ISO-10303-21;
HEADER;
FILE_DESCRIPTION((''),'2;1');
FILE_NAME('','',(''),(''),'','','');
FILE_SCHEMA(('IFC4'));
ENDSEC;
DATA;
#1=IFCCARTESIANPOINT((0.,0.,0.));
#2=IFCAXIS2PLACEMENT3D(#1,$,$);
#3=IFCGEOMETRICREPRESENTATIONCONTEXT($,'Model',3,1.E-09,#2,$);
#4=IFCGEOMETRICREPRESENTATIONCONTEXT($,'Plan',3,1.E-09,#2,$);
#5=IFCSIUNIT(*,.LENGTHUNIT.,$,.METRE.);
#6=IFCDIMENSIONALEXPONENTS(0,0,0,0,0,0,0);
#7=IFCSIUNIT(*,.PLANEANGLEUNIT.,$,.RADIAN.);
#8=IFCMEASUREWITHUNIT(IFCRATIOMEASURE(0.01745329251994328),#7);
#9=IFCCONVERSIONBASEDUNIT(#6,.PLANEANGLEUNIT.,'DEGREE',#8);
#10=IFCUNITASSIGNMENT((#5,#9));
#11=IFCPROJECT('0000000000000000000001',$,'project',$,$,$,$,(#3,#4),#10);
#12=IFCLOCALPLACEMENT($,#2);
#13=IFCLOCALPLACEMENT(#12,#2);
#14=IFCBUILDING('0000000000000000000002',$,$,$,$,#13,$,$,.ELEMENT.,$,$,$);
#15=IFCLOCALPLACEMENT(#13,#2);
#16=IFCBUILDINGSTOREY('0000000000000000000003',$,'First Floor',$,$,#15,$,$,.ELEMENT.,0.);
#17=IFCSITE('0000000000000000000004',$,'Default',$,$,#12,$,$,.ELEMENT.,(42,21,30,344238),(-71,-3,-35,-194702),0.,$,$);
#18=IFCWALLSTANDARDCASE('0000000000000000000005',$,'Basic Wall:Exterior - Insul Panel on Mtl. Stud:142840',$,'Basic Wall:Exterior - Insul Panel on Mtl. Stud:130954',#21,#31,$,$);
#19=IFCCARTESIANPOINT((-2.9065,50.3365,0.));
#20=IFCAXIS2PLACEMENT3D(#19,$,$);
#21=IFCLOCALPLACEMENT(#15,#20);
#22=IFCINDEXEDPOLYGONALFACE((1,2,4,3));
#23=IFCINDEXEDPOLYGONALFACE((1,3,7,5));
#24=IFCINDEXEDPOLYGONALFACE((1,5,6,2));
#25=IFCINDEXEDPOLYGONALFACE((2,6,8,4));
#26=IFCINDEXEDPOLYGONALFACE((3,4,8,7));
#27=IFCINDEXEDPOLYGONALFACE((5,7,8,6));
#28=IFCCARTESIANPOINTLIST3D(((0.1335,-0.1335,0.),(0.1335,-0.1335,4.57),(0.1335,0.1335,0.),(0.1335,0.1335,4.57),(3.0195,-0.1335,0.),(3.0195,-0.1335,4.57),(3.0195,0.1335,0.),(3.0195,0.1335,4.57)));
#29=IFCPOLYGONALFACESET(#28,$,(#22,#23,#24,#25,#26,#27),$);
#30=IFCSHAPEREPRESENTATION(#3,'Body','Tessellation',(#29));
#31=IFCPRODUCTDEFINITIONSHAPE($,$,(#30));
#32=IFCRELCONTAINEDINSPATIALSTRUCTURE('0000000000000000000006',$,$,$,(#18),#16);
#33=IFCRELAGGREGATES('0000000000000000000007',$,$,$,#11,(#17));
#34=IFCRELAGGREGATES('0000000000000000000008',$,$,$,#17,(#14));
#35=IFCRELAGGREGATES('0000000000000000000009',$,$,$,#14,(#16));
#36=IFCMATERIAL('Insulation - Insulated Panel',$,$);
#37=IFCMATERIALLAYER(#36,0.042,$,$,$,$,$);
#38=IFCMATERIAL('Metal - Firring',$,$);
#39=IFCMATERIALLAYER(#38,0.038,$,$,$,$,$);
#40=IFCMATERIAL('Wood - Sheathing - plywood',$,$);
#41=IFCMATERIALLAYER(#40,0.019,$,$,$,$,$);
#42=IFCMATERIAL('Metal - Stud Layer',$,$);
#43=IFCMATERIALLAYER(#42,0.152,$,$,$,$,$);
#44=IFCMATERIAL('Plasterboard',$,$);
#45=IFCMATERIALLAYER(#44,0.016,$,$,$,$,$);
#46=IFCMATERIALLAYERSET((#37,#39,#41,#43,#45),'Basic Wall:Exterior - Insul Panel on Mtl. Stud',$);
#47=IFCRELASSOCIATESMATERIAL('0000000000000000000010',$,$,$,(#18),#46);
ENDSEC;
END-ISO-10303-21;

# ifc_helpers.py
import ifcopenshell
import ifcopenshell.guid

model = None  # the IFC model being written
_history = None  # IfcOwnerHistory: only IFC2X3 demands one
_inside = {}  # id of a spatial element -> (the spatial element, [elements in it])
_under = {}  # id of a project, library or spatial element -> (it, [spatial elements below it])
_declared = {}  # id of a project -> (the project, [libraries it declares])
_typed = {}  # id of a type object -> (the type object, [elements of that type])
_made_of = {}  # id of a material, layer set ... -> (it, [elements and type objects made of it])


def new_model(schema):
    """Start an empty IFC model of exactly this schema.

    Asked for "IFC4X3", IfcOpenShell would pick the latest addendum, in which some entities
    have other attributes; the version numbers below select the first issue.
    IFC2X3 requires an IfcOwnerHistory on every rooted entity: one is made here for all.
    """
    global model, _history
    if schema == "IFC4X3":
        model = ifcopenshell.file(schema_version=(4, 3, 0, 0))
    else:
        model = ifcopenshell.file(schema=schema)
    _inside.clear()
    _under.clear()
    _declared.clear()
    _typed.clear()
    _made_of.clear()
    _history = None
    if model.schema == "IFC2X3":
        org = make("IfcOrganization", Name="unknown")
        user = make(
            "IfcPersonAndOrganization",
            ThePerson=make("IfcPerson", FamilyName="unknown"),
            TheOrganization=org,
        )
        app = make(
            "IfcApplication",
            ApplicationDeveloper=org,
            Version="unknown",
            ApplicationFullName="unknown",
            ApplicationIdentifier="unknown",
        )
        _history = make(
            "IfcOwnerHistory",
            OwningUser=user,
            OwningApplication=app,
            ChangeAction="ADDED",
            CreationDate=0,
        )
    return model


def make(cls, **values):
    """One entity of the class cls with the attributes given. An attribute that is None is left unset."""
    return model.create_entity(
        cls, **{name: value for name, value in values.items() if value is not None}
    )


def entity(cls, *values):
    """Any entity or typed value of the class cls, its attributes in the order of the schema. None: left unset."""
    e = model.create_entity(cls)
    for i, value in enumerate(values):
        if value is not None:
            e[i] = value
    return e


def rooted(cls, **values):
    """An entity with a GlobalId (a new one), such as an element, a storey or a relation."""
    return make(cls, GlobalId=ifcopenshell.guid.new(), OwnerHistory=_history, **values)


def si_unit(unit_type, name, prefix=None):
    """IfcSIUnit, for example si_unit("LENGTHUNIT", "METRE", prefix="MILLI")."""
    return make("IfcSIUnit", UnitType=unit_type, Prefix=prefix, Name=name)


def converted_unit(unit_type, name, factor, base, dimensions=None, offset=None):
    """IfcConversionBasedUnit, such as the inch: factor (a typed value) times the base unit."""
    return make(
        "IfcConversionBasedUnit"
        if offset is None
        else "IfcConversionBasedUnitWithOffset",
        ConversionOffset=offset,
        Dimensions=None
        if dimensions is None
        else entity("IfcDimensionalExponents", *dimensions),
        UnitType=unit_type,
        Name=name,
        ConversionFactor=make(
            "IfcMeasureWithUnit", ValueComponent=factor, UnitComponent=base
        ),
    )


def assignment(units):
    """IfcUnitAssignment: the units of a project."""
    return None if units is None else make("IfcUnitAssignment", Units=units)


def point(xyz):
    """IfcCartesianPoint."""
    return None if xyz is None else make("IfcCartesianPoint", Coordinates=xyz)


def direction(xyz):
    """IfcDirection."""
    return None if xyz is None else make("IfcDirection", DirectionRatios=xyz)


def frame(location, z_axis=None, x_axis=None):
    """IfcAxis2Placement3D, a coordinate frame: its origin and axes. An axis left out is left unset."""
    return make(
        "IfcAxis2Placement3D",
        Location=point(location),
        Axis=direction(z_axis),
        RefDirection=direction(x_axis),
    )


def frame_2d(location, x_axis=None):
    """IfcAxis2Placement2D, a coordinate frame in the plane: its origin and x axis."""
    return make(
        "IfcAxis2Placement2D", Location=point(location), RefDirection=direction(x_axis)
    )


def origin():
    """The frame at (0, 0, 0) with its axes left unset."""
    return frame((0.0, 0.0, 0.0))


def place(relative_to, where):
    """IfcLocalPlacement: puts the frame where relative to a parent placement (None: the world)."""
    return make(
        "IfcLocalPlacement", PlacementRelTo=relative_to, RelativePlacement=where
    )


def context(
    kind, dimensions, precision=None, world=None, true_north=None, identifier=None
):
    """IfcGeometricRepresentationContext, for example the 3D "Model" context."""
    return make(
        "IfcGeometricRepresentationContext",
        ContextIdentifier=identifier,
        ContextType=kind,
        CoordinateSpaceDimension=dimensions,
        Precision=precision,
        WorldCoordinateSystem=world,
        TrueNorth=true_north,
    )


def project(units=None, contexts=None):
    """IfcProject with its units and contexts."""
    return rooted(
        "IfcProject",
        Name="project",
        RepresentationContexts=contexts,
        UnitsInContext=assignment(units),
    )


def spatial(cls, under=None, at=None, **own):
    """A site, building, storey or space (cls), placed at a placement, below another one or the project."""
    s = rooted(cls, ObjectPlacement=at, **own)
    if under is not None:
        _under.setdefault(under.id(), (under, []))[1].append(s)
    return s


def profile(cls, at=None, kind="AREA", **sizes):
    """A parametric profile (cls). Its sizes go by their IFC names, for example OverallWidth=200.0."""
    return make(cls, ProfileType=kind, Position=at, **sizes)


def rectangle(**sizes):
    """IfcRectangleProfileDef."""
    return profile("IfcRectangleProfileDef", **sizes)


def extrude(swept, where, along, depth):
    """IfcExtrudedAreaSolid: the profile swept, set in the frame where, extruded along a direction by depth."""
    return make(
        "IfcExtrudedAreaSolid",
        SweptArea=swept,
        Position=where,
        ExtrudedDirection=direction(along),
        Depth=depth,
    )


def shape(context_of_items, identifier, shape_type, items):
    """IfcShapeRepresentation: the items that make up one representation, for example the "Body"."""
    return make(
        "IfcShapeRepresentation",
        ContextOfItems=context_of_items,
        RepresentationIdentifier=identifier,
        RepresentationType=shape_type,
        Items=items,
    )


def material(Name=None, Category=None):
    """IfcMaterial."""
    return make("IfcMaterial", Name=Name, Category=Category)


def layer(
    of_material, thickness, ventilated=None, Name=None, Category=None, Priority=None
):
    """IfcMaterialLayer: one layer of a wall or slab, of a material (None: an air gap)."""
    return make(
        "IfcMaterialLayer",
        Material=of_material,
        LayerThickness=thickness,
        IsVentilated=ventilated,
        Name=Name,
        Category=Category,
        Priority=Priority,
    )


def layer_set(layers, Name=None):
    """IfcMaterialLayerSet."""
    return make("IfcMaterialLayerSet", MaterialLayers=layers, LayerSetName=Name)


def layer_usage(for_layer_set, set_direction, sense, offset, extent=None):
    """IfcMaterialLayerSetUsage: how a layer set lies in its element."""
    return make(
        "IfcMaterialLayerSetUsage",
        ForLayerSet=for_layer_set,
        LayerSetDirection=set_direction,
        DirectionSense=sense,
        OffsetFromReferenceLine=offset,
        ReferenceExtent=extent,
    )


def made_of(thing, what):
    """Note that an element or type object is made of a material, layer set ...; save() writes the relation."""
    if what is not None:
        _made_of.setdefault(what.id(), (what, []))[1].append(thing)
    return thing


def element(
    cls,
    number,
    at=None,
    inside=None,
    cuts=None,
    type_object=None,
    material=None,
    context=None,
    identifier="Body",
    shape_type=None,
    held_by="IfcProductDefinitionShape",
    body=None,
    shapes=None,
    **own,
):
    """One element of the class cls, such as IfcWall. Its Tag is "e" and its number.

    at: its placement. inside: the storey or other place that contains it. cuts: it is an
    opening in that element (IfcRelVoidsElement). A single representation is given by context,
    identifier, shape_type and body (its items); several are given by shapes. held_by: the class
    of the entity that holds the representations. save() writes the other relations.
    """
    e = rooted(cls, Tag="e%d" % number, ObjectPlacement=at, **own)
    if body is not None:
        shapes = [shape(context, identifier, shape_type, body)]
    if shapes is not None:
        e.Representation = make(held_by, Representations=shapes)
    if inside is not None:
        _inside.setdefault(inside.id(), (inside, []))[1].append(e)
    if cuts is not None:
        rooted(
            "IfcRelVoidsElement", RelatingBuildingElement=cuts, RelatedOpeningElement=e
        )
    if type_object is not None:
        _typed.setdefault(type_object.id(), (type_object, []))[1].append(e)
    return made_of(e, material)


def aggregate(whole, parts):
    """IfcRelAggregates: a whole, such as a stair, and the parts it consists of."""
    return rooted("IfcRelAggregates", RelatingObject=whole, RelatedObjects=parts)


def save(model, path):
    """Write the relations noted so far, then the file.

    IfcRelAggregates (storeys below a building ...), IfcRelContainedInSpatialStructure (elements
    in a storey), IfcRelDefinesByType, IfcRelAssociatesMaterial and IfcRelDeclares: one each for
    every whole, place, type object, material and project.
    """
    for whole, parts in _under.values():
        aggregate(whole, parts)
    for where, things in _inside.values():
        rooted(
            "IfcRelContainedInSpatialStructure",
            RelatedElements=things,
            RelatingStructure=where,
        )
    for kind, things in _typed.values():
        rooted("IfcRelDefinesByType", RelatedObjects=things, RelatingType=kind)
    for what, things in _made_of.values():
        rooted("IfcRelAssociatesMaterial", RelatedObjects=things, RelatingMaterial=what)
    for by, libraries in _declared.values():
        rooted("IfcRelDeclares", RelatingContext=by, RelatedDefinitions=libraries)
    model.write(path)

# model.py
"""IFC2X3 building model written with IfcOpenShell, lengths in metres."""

from ifc_helpers import new_model, entity, si_unit, converted_unit, frame, frame_2d, origin, place, context, project, spatial, rectangle, extrude, material, layer, layer_set, layer_usage, element, save


model = new_model("IFC2X3")

# Units and contexts
model_context = context("Model", 3, precision=1e-09, world=origin())
plan_context = context("Plan", 3, precision=1e-09, world=origin())
ifc_project = project(units=[si_unit("LENGTHUNIT", "METRE"), converted_unit("PLANEANGLEUNIT", "DEGREE", entity("IfcRatioMeasure", 0.01745329251994328), si_unit("PLANEANGLEUNIT", "RADIAN"), dimensions=[0, 0, 0, 0, 0, 0, 0])], contexts=[model_context, plan_context])

# Site, building, storey
site_placement = place(None, origin())
site = spatial("IfcSite", under=ifc_project, at=site_placement, Name="Default", CompositionType="ELEMENT", RefLatitude=(42, 21, 30, 344238), RefLongitude=(-71, -3, -35, -194702), RefElevation=0.0)
building_placement = place(site_placement, origin())
building = spatial("IfcBuilding", under=site, at=building_placement, CompositionType="ELEMENT")
storey_placement = place(building_placement, origin())
storey = spatial("IfcBuildingStorey", under=building, at=storey_placement, Name="First Floor", CompositionType="ELEMENT", Elevation=0.0)

# Shared definitions
ifc_material_1 = material(Name="Insulation - Insulated Panel")
ifc_layer_1 = layer(ifc_material_1, 0.042)
ifc_material_2 = material(Name="Metal - Firring")
ifc_layer_2 = layer(ifc_material_2, 0.038)
ifc_material_3 = material(Name="Wood - Sheathing - plywood")
ifc_layer_3 = layer(ifc_material_3, 0.019)
ifc_material_4 = material(Name="Metal - Stud Layer")
ifc_layer_4 = layer(ifc_material_4, 0.152)
ifc_material_5 = material(Name="Plasterboard")
ifc_layer_5 = layer(ifc_material_5, 0.016)
ifc_layer_set_1 = layer_set([ifc_layer_1, ifc_layer_2, ifc_layer_3, ifc_layer_4, ifc_layer_5], Name="Basic Wall:Exterior - Insul Panel on Mtl. Stud")
ifc_layer_usage_1 = layer_usage(ifc_layer_set_1, "AXIS2", "NEGATIVE", 0.1335)

# Wall
wall_1_placement = place(storey_placement, frame((-2.9065, 50.3365, 0.0)))
element("IfcWallStandardCase", 1, at=wall_1_placement, inside=storey, material=ifc_layer_usage_1, Name="Basic Wall:Exterior - Insul Panel on Mtl. Stud:142840", ObjectType="Basic Wall:Exterior - Insul Panel on Mtl. Stud:130954", context=model_context, shape_type="SweptSolid", body=[
    extrude(rectangle(XDim=2.886, YDim=0.267, at=frame_2d((1.5765, 0.0), x_axis=(-1.0, 0.0))), origin(), (0.0, 0.0, 1.0), 4.57),
])

save(model, "model.ifc")
